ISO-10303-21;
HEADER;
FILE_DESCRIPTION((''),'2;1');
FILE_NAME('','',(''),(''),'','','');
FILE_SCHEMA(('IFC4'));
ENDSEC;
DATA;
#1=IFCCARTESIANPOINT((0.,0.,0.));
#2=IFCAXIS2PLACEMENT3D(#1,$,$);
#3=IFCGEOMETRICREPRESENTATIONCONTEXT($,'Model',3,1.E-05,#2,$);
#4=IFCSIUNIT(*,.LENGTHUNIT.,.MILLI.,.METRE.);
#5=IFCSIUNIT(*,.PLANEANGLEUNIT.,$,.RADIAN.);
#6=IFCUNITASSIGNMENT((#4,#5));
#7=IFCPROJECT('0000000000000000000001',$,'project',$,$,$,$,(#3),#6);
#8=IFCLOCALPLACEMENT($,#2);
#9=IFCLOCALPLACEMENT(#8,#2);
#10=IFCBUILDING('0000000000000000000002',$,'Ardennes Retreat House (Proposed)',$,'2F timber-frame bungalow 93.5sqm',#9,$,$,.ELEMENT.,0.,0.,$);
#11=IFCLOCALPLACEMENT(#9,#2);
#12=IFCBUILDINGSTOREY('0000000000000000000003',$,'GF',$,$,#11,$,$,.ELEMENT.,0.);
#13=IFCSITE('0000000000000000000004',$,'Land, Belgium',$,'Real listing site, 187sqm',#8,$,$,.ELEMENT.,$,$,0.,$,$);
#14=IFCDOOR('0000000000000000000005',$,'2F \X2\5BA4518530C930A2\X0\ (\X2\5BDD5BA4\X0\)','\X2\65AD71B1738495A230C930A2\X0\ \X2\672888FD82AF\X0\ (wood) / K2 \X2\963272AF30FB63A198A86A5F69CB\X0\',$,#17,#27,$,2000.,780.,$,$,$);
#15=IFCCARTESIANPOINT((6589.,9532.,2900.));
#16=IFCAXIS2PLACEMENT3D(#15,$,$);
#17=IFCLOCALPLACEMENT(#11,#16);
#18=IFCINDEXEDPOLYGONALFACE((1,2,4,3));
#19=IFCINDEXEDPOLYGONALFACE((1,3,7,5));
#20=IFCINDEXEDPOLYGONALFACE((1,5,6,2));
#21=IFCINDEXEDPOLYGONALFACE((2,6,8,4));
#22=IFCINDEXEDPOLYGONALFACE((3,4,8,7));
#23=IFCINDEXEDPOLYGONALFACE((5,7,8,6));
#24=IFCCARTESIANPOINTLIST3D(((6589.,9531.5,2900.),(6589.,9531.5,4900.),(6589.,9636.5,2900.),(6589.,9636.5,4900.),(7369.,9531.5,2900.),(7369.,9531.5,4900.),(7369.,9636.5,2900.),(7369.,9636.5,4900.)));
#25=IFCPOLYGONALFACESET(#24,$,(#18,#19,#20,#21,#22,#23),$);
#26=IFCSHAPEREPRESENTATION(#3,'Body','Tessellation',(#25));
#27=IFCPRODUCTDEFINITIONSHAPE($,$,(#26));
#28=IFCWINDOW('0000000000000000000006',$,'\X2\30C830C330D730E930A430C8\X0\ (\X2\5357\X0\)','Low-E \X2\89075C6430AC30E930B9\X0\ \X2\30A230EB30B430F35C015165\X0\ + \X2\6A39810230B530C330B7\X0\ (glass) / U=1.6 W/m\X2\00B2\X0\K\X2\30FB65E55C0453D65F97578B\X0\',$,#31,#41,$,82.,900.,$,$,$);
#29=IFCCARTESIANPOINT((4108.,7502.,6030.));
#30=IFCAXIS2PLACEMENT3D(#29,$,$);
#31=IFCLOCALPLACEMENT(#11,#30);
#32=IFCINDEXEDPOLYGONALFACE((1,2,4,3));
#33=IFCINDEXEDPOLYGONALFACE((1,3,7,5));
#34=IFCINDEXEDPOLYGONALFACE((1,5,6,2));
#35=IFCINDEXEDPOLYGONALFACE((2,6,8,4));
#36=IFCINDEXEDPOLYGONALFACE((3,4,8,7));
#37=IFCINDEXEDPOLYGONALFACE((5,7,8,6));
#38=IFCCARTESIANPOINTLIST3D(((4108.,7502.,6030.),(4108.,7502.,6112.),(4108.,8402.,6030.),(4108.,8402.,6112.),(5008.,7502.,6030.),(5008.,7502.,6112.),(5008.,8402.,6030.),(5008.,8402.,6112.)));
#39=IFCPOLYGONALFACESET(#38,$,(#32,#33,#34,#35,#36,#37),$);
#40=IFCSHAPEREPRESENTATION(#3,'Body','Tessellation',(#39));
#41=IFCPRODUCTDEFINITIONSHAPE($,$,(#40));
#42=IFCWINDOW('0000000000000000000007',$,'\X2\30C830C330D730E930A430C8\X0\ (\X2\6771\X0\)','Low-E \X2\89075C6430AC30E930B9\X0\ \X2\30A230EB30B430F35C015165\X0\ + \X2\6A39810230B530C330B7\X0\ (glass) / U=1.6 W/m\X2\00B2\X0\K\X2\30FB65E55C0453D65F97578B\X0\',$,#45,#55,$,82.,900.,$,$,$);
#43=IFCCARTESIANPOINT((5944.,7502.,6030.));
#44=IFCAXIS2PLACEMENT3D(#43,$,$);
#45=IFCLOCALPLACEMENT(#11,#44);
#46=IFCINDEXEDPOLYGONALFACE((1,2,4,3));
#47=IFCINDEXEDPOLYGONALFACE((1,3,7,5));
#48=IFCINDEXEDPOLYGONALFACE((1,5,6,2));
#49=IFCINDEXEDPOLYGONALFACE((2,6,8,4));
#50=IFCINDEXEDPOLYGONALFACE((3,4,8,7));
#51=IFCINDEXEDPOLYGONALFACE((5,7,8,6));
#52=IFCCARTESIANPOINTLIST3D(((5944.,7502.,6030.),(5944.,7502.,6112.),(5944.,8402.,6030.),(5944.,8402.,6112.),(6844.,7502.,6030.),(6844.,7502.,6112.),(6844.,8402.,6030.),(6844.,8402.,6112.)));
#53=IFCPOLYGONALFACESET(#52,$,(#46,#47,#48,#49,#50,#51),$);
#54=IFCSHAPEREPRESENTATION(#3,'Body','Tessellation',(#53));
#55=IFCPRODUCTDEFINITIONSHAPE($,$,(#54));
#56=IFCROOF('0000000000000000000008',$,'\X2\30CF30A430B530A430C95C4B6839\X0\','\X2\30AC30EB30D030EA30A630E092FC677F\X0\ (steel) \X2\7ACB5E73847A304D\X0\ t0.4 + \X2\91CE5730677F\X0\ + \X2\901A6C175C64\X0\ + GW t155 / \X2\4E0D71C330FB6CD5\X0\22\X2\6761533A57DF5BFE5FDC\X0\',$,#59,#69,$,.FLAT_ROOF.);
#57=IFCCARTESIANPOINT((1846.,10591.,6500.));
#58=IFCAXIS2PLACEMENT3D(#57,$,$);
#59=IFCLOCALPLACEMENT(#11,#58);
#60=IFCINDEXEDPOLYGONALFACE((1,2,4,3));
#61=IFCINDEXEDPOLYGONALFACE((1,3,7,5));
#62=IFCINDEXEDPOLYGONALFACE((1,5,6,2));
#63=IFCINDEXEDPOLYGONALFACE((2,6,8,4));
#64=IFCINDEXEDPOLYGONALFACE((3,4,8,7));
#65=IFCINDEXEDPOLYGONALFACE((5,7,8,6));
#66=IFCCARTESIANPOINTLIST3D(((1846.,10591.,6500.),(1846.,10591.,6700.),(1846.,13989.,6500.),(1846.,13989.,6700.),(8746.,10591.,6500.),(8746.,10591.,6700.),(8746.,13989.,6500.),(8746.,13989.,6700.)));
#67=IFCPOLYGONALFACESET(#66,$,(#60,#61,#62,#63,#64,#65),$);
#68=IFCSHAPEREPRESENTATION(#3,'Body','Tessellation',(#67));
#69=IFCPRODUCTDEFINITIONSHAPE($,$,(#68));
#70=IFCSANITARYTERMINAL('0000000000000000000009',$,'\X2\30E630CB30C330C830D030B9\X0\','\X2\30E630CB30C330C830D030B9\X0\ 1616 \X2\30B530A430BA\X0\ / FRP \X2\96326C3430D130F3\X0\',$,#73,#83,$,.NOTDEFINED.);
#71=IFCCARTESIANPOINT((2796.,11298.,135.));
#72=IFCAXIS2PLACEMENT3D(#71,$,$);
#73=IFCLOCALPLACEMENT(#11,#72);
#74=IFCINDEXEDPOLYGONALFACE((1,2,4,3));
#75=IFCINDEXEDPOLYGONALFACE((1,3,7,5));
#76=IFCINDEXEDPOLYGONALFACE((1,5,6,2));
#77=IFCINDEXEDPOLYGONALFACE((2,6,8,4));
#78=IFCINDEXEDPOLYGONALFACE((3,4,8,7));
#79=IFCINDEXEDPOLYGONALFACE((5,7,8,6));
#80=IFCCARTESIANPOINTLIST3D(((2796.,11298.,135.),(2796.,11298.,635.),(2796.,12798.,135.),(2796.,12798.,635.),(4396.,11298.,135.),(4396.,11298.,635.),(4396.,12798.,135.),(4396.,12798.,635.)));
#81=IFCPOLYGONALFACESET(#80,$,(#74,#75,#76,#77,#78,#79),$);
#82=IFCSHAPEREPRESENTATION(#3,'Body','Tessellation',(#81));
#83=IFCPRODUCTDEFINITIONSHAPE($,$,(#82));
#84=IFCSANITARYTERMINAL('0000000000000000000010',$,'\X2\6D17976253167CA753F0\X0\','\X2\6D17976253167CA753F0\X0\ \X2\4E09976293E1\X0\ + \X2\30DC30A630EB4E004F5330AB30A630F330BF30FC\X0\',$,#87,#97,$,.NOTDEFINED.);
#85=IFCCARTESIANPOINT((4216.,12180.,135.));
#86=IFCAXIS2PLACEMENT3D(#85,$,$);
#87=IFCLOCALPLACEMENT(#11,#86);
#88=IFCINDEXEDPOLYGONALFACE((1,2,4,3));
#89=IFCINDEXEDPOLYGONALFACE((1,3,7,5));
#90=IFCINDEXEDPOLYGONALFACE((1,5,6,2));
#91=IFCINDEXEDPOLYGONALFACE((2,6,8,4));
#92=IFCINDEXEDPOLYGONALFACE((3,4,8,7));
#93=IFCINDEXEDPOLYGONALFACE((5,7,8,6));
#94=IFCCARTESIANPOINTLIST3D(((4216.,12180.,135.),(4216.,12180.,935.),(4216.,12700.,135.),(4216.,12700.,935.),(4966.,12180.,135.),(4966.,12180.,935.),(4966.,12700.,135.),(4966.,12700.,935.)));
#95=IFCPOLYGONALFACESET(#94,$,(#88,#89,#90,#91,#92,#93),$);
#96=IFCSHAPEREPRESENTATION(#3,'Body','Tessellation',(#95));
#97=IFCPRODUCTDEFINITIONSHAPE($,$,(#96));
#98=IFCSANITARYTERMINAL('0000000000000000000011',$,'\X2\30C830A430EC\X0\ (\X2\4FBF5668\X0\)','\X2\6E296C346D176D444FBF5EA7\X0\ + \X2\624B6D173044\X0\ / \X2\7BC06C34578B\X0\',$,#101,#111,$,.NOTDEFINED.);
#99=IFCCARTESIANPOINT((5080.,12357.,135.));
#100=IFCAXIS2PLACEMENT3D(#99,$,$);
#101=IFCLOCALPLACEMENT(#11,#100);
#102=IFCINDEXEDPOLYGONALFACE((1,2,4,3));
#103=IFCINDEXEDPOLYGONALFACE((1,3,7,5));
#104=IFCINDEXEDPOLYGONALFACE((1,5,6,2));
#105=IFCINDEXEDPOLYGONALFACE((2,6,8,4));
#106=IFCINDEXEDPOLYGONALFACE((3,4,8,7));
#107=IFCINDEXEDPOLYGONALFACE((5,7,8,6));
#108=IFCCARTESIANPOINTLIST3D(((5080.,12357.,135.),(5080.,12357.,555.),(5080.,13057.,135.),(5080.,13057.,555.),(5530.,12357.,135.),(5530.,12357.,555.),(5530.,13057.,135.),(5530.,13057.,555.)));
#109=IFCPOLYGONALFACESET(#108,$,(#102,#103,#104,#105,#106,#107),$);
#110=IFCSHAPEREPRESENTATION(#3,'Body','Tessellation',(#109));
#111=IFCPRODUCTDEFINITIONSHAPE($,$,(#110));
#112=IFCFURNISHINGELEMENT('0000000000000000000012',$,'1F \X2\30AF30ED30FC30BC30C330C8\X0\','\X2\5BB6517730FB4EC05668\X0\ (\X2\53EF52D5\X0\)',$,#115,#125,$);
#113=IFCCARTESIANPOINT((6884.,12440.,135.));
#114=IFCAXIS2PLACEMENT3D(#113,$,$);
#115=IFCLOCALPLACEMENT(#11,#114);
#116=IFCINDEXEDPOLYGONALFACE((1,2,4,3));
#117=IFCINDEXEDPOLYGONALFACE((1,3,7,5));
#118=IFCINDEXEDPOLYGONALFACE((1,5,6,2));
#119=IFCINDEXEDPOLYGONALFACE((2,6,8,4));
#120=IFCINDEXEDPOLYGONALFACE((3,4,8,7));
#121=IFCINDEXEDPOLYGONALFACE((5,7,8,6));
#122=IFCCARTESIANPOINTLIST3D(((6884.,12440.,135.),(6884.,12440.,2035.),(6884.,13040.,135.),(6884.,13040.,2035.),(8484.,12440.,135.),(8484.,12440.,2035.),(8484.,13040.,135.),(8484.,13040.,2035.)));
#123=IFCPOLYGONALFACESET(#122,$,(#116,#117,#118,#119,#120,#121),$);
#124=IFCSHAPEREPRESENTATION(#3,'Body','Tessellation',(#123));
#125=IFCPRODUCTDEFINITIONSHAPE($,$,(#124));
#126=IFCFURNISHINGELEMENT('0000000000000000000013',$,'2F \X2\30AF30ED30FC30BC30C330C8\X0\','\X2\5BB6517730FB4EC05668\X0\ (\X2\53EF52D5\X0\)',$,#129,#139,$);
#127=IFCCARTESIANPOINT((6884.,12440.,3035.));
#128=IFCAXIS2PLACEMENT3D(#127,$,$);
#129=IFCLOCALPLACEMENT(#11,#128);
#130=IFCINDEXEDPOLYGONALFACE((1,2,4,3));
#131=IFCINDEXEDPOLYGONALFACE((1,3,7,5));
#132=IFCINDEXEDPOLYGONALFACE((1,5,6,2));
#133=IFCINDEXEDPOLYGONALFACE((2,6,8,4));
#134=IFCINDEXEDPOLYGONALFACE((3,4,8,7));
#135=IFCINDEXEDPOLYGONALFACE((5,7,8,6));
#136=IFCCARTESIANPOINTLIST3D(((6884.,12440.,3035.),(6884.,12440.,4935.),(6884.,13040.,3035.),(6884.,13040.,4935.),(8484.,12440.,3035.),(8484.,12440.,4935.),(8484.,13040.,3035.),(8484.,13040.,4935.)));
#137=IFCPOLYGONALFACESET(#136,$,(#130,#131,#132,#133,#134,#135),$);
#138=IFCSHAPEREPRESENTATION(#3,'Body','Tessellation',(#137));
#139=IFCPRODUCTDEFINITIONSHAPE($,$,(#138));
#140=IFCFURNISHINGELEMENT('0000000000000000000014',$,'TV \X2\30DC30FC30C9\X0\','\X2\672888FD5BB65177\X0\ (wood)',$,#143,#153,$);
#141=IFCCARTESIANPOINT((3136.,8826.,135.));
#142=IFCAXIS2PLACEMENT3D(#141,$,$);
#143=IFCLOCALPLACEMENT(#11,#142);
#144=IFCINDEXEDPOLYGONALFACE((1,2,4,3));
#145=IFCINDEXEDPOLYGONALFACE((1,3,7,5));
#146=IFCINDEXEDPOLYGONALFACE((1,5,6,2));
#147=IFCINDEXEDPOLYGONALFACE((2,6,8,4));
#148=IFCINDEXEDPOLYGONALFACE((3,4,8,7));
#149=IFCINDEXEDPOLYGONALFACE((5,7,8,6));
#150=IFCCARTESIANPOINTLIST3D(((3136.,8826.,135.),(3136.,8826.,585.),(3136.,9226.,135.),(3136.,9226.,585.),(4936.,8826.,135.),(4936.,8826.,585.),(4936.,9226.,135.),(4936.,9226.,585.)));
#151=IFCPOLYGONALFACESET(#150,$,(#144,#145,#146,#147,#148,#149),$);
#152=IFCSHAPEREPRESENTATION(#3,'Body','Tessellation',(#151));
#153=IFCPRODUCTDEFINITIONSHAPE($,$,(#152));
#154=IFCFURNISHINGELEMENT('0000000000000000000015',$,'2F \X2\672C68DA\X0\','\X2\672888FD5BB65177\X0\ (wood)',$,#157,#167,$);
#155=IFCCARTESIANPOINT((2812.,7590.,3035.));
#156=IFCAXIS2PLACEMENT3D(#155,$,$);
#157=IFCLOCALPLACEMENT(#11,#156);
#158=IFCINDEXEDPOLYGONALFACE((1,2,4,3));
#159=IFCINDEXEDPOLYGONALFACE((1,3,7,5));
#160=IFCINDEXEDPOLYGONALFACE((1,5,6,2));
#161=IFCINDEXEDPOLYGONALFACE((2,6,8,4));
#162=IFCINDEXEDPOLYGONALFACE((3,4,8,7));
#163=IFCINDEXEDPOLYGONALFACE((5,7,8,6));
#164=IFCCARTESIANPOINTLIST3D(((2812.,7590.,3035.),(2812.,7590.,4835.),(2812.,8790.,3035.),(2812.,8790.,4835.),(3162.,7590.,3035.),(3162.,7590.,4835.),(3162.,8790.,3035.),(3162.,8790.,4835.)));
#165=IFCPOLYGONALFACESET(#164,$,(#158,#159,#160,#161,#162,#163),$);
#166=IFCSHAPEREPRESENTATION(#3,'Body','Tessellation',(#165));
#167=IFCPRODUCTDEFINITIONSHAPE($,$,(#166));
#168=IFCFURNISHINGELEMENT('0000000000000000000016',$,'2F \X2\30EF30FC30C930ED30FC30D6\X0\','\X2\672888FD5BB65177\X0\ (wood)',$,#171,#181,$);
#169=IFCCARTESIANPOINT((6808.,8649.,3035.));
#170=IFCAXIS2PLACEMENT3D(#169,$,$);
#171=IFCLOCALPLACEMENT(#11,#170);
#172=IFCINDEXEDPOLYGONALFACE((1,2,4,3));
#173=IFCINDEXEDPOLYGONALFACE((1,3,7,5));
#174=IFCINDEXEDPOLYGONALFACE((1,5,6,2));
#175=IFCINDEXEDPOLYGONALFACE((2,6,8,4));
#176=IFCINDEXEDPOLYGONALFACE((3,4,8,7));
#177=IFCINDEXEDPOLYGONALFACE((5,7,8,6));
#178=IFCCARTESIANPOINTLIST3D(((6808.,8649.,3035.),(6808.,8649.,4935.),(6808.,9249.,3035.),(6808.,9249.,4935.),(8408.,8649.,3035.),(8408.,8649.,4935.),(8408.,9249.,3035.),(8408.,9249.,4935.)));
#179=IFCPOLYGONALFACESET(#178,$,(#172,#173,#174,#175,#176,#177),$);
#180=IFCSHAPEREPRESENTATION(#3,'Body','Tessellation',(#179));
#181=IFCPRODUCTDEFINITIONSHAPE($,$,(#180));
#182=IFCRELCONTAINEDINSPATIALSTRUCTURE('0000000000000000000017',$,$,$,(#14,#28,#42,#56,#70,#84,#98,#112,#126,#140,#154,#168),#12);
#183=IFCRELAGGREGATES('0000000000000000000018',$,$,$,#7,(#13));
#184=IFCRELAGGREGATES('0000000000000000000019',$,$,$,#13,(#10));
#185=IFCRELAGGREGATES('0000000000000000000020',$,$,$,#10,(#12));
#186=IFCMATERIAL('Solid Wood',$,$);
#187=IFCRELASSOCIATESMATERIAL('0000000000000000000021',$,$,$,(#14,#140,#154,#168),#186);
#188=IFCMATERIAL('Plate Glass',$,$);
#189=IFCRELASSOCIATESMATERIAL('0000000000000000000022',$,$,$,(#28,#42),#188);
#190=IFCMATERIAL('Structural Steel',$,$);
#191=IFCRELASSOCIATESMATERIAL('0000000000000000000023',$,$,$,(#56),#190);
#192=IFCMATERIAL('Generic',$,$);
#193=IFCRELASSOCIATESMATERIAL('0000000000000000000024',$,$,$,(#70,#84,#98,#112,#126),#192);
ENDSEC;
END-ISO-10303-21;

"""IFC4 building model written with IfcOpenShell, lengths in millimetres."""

from ifc_helpers import new_model, si_unit, frame, frame_2d, origin, place, context, project, spatial, rectangle, extrude, material, element, save


model = new_model("IFC4")

# Units and contexts
model_context = context("Model", 3, precision=1e-05, world=origin())
ifc_project = project(units=[si_unit("LENGTHUNIT", "METRE", prefix="MILLI"), si_unit("PLANEANGLEUNIT", "RADIAN")], contexts=[model_context])

# Site, building, storey
site_placement = place(None, origin())
site = spatial("IfcSite", under=ifc_project, at=site_placement, Name="Land, Belgium", ObjectType="Real listing site, 187sqm", CompositionType="ELEMENT", RefElevation=0.0)
building_placement = place(site_placement, origin())
building = spatial("IfcBuilding", under=site, at=building_placement, Name="Ardennes Retreat House (Proposed)", ObjectType="2F timber-frame bungalow 93.5sqm", CompositionType="ELEMENT", ElevationOfRefHeight=0.0, ElevationOfTerrain=0.0)
storey_placement = place(building_placement, origin())
storey = spatial("IfcBuildingStorey", under=building, at=storey_placement, Name="GF", CompositionType="ELEMENT", Elevation=0.0)

# Shared definitions
ifc_material_1 = material(Name="Solid Wood")
ifc_material_2 = material(Name="Plate Glass")

# Door
door_1_placement = place(storey_placement, frame((6589.0, 9532.0, 2900.0)))
element("IfcDoor", 1, at=door_1_placement, inside=storey, material=ifc_material_1, Name="2F 室内ドア (寝室)", Description="断熱玄関ドア 木製芯 (wood) / K2 防犯・採風機構", OverallHeight=2000.0, OverallWidth=780.0, context=model_context, shape_type="SweptSolid", body=[
    extrude(rectangle(XDim=780.0, YDim=105.0, at=frame_2d((390.0, 52.0))), frame((6589.0, 9532.0, 2900.0)), (0.0, 0.0, 1.0), 2000.0),
])

# Windows
window_1_placement = place(storey_placement, frame((4108.0, 7502.0, 6030.0)))
element("IfcWindow", 2, at=window_1_placement, inside=storey, material=ifc_material_2, Name="トップライト (南)", Description="Low-E 複層ガラス アルゴン封入 + 樹脂サッシ (glass) / U=1.6 W/m²K・日射取得型", OverallHeight=82.0, OverallWidth=900.0, context=model_context, shape_type="SweptSolid", body=[
    extrude(rectangle(XDim=900.0, YDim=900.0, at=frame_2d((450.0, 450.0))), frame((4108.0, 7502.0, 6030.0)), (0.0, 0.0, 1.0), 82.0),
])
window_2_placement = place(storey_placement, frame((5944.0, 7502.0, 6030.0)))
element("IfcWindow", 3, at=window_2_placement, inside=storey, material=ifc_material_2, Name="トップライト (東)", Description="Low-E 複層ガラス アルゴン封入 + 樹脂サッシ (glass) / U=1.6 W/m²K・日射取得型", OverallHeight=82.0, OverallWidth=900.0, context=model_context, shape_type="SweptSolid", body=[
    extrude(rectangle(XDim=900.0, YDim=900.0, at=frame_2d((450.0, 450.0))), frame((5944.0, 7502.0, 6030.0)), (0.0, 0.0, 1.0), 82.0),
])

# Roof
ifc_material_3 = material(Name="Structural Steel")
roof_placement = place(storey_placement, frame((1846.0, 10591.0, 6500.0)))
element("IfcRoof", 4, at=roof_placement, inside=storey, material=ifc_material_3, Name="ハイサイド屋根", Description="ガルバリウム鋼板 (steel) 立平葺き t0.4 + 野地板 + 通気層 + GW t155 / 不燃・法22条区域対応", PredefinedType="FLAT_ROOF", context=model_context, shape_type="SweptSolid", body=[
    extrude(rectangle(XDim=6900.0, YDim=3398.0, at=frame_2d((3450.0, 1699.0))), frame((1846.0, 10591.0, 6500.0)), (0.0, 0.0, 1.0), 200.0),
])

# Sanitary terminals
ifc_material_4 = material(Name="Generic")
sanitary_terminal_1_placement = place(storey_placement, frame((2796.0, 11298.0, 135.0)))
element("IfcSanitaryTerminal", 5, at=sanitary_terminal_1_placement, inside=storey, material=ifc_material_4, Name="ユニットバス", Description="ユニットバス 1616 サイズ / FRP 防水パン", PredefinedType="NOTDEFINED", context=model_context, shape_type="SweptSolid", body=[
    extrude(rectangle(XDim=1600.0, YDim=1500.0, at=frame_2d((800.0, 750.0))), frame((2796.0, 11298.0, 135.0)), (0.0, 0.0, 1.0), 500.0),
])
sanitary_terminal_2_placement = place(storey_placement, frame((4216.0, 12180.0, 135.0)))
element("IfcSanitaryTerminal", 6, at=sanitary_terminal_2_placement, inside=storey, material=ifc_material_4, Name="洗面化粧台", Description="洗面化粧台 三面鏡 + ボウル一体カウンター", PredefinedType="NOTDEFINED", context=model_context, shape_type="SweptSolid", body=[
    extrude(rectangle(XDim=750.0, YDim=520.0, at=frame_2d((375.0, 260.0))), frame((4216.0, 12180.0, 135.0)), (0.0, 0.0, 1.0), 800.0),
])
sanitary_terminal_3_placement = place(storey_placement, frame((5080.0, 12357.0, 135.0)))
element("IfcSanitaryTerminal", 7, at=sanitary_terminal_3_placement, inside=storey, material=ifc_material_4, Name="トイレ (便器)", Description="温水洗浄便座 + 手洗い / 節水型", PredefinedType="NOTDEFINED", context=model_context, shape_type="SweptSolid", body=[
    extrude(rectangle(XDim=450.0, YDim=700.0, at=frame_2d((225.0, 350.0))), frame((5080.0, 12357.0, 135.0)), (0.0, 0.0, 1.0), 420.0),
])

# Furnishing elements
furnishing_1_placement = place(storey_placement, frame((6884.0, 12440.0, 135.0)))
element("IfcFurnishingElement", 8, at=furnishing_1_placement, inside=storey, material=ifc_material_4, Name="1F クローゼット", Description="家具・什器 (可動)", context=model_context, shape_type="SweptSolid", body=[
    extrude(rectangle(XDim=1600.0, YDim=600.0, at=frame_2d((800.0, 300.0))), frame((6884.0, 12440.0, 135.0)), (0.0, 0.0, 1.0), 1900.0),
])
furnishing_2_placement = place(storey_placement, frame((6884.0, 12440.0, 3035.0)))
element("IfcFurnishingElement", 9, at=furnishing_2_placement, inside=storey, material=ifc_material_4, Name="2F クローゼット", Description="家具・什器 (可動)", context=model_context, shape_type="SweptSolid", body=[
    extrude(rectangle(XDim=1600.0, YDim=600.0, at=frame_2d((800.0, 300.0))), frame((6884.0, 12440.0, 3035.0)), (0.0, 0.0, 1.0), 1900.0),
])
furnishing_3_placement = place(storey_placement, frame((3136.0, 8826.0, 135.0)))
element("IfcFurnishingElement", 10, at=furnishing_3_placement, inside=storey, material=ifc_material_1, Name="TV ボード", Description="木製家具 (wood)", context=model_context, shape_type="SweptSolid", body=[
    extrude(rectangle(XDim=1800.0, YDim=400.0, at=frame_2d((900.0, 200.0))), frame((3136.0, 8826.0, 135.0)), (0.0, 0.0, 1.0), 450.0),
])
furnishing_4_placement = place(storey_placement, frame((2812.0, 7590.0, 3035.0)))
element("IfcFurnishingElement", 11, at=furnishing_4_placement, inside=storey, material=ifc_material_1, Name="2F 本棚", Description="木製家具 (wood)", context=model_context, shape_type="SweptSolid", body=[
    extrude(rectangle(XDim=350.0, YDim=1200.0, at=frame_2d((175.0, 600.0))), frame((2812.0, 7590.0, 3035.0)), (0.0, 0.0, 1.0), 1800.0),
])
furnishing_5_placement = place(storey_placement, frame((6808.0, 8649.0, 3035.0)))
element("IfcFurnishingElement", 12, at=furnishing_5_placement, inside=storey, material=ifc_material_1, Name="2F ワードローブ", Description="木製家具 (wood)", context=model_context, shape_type="SweptSolid", body=[
    extrude(rectangle(XDim=1600.0, YDim=600.0, at=frame_2d((800.0, 300.0))), frame((6808.0, 8649.0, 3035.0)), (0.0, 0.0, 1.0), 1900.0),
])

save(model, "model.ifc")
